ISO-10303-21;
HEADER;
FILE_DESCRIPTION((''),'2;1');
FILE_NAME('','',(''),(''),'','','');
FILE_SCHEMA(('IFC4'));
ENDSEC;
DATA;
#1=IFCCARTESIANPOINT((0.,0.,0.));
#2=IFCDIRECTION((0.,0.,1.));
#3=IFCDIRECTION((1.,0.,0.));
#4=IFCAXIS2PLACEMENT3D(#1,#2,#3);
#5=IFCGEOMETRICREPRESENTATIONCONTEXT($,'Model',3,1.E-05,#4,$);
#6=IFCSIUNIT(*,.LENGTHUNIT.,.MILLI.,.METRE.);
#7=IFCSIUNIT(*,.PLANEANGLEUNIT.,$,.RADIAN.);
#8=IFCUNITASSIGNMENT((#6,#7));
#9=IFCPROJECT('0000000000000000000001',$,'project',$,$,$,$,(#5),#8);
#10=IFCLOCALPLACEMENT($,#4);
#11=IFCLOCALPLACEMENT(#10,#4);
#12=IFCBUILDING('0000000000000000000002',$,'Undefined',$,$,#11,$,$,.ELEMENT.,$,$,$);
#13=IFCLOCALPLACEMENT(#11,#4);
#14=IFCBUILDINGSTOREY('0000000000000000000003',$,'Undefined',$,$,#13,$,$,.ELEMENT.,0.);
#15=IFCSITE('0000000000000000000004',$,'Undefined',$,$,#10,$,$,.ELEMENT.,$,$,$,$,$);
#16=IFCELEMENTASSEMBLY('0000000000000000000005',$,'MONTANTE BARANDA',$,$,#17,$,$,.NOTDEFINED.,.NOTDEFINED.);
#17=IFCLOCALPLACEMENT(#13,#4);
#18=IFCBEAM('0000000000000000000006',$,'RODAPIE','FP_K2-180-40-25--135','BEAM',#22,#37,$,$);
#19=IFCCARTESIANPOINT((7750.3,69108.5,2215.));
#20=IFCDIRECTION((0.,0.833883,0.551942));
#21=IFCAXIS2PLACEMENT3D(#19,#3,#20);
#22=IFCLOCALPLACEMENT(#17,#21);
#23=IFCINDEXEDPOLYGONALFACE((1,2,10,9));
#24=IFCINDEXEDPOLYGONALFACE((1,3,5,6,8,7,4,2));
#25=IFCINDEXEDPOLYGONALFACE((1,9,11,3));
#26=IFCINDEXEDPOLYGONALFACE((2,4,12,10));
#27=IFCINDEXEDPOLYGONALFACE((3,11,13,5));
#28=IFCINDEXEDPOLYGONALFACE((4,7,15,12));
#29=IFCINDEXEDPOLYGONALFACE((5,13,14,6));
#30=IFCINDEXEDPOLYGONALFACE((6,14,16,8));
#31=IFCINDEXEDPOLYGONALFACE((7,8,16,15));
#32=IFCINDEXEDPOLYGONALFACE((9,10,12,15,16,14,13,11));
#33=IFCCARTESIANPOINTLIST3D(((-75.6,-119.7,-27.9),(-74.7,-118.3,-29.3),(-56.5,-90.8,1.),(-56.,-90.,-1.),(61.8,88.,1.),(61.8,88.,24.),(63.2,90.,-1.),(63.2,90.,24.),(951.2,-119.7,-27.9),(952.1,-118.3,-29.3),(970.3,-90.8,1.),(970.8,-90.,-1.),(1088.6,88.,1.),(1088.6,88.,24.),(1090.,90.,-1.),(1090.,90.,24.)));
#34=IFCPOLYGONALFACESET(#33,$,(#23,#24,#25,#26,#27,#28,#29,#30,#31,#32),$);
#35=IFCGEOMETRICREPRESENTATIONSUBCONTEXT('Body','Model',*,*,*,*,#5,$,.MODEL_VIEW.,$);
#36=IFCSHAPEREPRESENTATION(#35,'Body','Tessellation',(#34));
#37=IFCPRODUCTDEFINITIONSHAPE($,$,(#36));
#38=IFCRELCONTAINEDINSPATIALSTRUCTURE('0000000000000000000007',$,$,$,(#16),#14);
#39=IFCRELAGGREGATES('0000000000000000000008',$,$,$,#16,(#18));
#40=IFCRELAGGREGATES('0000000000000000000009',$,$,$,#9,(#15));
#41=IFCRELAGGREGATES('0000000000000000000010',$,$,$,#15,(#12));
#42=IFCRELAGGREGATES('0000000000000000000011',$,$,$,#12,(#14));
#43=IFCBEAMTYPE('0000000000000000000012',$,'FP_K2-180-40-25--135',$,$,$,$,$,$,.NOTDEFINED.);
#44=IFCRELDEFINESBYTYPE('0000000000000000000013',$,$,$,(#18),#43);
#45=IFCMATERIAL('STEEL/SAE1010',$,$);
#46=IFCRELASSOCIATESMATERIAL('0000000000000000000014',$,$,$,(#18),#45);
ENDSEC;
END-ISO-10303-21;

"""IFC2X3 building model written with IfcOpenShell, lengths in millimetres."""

from ifc_helpers import new_model, si_unit, frame, origin_with_axes, place, context, subcontext, project, spatial, polyline, outline, extrude, clip, halfspace, material, type_object, element, aggregate, save


model = new_model("IFC2X3")

# Units and contexts
model_context = context("Model", 3, precision=1e-05, world=origin_with_axes())
body_context = subcontext(model_context, "Body", "Model", "MODEL_VIEW")
ifc_project = project(units=[si_unit("LENGTHUNIT", "METRE", prefix="MILLI"), si_unit("PLANEANGLEUNIT", "RADIAN")], contexts=[model_context])

# Site, building, storey
site_placement = place(None, origin_with_axes())
site = spatial("IfcSite", under=ifc_project, at=site_placement, Name="Undefined", CompositionType="ELEMENT")
building_placement = place(site_placement, origin_with_axes())
building = spatial("IfcBuilding", under=site, at=building_placement, Name="Undefined", CompositionType="ELEMENT")
storey_placement = place(building_placement, origin_with_axes())
storey = spatial("IfcBuildingStorey", under=building, at=storey_placement, Name="Undefined", CompositionType="ELEMENT", Elevation=0.0)

# Element assembly, beam
assembly_1_placement = place(storey_placement, origin_with_axes())
assembly_1 = element("IfcElementAssembly", 1, at=assembly_1_placement, inside=storey, Name="MONTANTE BARANDA", AssemblyPlace="NOTDEFINED", PredefinedType="NOTDEFINED")
ifc_material_1 = material(Name="STEEL/SAE1010")
beam_type_1 = type_object("IfcBeamType", Name="FP_K2-180-40-25--135", PredefinedType="NOTDEFINED")
beam_1_placement = place(assembly_1_placement, frame((7750.3, 69108.5, 2215.0), z_axis=(1.0, 0.0, 0.0), x_axis=(0.0, 0.833883, 0.551942)))
beam_1 = element("IfcBeam", 2, at=beam_1_placement, type_object=beam_type_1, material=ifc_material_1, Name="RODAPIE", Description="FP_K2-180-40-25--135", ObjectType="BEAM", context=body_context, shape_type="Clipping", body=[
    clip(clip(extrude(outline(polyline([(90.8, 1.0), (119.7, -27.9), (118.3, -29.3), (90.0, -1.0), (-90.0, -1.0), (-90.0, 24.0), (-88.0, 24.0), (-88.0, 1.0), (90.8, 1.0)])), frame((1304.0, 0.0, 0.0), z_axis=(-1.0, 0.0, 0.0), x_axis=(0.0, -1.0, 0.0)), (0.0, 0.0, 1.0), 1440.6), halfspace(frame((1030.4, 0.0, 0.0), z_axis=(0.833883, -0.551942, 0.0), x_axis=(0.0, 0.0, 1.0)), False)), halfspace(frame((3.6, 0.0, 0.0), z_axis=(0.833883, -0.551942, 0.0), x_axis=(0.0, 0.0, -1.0)), True)),
])

aggregate(assembly_1, [beam_1])

save(model, "model.ifc")
